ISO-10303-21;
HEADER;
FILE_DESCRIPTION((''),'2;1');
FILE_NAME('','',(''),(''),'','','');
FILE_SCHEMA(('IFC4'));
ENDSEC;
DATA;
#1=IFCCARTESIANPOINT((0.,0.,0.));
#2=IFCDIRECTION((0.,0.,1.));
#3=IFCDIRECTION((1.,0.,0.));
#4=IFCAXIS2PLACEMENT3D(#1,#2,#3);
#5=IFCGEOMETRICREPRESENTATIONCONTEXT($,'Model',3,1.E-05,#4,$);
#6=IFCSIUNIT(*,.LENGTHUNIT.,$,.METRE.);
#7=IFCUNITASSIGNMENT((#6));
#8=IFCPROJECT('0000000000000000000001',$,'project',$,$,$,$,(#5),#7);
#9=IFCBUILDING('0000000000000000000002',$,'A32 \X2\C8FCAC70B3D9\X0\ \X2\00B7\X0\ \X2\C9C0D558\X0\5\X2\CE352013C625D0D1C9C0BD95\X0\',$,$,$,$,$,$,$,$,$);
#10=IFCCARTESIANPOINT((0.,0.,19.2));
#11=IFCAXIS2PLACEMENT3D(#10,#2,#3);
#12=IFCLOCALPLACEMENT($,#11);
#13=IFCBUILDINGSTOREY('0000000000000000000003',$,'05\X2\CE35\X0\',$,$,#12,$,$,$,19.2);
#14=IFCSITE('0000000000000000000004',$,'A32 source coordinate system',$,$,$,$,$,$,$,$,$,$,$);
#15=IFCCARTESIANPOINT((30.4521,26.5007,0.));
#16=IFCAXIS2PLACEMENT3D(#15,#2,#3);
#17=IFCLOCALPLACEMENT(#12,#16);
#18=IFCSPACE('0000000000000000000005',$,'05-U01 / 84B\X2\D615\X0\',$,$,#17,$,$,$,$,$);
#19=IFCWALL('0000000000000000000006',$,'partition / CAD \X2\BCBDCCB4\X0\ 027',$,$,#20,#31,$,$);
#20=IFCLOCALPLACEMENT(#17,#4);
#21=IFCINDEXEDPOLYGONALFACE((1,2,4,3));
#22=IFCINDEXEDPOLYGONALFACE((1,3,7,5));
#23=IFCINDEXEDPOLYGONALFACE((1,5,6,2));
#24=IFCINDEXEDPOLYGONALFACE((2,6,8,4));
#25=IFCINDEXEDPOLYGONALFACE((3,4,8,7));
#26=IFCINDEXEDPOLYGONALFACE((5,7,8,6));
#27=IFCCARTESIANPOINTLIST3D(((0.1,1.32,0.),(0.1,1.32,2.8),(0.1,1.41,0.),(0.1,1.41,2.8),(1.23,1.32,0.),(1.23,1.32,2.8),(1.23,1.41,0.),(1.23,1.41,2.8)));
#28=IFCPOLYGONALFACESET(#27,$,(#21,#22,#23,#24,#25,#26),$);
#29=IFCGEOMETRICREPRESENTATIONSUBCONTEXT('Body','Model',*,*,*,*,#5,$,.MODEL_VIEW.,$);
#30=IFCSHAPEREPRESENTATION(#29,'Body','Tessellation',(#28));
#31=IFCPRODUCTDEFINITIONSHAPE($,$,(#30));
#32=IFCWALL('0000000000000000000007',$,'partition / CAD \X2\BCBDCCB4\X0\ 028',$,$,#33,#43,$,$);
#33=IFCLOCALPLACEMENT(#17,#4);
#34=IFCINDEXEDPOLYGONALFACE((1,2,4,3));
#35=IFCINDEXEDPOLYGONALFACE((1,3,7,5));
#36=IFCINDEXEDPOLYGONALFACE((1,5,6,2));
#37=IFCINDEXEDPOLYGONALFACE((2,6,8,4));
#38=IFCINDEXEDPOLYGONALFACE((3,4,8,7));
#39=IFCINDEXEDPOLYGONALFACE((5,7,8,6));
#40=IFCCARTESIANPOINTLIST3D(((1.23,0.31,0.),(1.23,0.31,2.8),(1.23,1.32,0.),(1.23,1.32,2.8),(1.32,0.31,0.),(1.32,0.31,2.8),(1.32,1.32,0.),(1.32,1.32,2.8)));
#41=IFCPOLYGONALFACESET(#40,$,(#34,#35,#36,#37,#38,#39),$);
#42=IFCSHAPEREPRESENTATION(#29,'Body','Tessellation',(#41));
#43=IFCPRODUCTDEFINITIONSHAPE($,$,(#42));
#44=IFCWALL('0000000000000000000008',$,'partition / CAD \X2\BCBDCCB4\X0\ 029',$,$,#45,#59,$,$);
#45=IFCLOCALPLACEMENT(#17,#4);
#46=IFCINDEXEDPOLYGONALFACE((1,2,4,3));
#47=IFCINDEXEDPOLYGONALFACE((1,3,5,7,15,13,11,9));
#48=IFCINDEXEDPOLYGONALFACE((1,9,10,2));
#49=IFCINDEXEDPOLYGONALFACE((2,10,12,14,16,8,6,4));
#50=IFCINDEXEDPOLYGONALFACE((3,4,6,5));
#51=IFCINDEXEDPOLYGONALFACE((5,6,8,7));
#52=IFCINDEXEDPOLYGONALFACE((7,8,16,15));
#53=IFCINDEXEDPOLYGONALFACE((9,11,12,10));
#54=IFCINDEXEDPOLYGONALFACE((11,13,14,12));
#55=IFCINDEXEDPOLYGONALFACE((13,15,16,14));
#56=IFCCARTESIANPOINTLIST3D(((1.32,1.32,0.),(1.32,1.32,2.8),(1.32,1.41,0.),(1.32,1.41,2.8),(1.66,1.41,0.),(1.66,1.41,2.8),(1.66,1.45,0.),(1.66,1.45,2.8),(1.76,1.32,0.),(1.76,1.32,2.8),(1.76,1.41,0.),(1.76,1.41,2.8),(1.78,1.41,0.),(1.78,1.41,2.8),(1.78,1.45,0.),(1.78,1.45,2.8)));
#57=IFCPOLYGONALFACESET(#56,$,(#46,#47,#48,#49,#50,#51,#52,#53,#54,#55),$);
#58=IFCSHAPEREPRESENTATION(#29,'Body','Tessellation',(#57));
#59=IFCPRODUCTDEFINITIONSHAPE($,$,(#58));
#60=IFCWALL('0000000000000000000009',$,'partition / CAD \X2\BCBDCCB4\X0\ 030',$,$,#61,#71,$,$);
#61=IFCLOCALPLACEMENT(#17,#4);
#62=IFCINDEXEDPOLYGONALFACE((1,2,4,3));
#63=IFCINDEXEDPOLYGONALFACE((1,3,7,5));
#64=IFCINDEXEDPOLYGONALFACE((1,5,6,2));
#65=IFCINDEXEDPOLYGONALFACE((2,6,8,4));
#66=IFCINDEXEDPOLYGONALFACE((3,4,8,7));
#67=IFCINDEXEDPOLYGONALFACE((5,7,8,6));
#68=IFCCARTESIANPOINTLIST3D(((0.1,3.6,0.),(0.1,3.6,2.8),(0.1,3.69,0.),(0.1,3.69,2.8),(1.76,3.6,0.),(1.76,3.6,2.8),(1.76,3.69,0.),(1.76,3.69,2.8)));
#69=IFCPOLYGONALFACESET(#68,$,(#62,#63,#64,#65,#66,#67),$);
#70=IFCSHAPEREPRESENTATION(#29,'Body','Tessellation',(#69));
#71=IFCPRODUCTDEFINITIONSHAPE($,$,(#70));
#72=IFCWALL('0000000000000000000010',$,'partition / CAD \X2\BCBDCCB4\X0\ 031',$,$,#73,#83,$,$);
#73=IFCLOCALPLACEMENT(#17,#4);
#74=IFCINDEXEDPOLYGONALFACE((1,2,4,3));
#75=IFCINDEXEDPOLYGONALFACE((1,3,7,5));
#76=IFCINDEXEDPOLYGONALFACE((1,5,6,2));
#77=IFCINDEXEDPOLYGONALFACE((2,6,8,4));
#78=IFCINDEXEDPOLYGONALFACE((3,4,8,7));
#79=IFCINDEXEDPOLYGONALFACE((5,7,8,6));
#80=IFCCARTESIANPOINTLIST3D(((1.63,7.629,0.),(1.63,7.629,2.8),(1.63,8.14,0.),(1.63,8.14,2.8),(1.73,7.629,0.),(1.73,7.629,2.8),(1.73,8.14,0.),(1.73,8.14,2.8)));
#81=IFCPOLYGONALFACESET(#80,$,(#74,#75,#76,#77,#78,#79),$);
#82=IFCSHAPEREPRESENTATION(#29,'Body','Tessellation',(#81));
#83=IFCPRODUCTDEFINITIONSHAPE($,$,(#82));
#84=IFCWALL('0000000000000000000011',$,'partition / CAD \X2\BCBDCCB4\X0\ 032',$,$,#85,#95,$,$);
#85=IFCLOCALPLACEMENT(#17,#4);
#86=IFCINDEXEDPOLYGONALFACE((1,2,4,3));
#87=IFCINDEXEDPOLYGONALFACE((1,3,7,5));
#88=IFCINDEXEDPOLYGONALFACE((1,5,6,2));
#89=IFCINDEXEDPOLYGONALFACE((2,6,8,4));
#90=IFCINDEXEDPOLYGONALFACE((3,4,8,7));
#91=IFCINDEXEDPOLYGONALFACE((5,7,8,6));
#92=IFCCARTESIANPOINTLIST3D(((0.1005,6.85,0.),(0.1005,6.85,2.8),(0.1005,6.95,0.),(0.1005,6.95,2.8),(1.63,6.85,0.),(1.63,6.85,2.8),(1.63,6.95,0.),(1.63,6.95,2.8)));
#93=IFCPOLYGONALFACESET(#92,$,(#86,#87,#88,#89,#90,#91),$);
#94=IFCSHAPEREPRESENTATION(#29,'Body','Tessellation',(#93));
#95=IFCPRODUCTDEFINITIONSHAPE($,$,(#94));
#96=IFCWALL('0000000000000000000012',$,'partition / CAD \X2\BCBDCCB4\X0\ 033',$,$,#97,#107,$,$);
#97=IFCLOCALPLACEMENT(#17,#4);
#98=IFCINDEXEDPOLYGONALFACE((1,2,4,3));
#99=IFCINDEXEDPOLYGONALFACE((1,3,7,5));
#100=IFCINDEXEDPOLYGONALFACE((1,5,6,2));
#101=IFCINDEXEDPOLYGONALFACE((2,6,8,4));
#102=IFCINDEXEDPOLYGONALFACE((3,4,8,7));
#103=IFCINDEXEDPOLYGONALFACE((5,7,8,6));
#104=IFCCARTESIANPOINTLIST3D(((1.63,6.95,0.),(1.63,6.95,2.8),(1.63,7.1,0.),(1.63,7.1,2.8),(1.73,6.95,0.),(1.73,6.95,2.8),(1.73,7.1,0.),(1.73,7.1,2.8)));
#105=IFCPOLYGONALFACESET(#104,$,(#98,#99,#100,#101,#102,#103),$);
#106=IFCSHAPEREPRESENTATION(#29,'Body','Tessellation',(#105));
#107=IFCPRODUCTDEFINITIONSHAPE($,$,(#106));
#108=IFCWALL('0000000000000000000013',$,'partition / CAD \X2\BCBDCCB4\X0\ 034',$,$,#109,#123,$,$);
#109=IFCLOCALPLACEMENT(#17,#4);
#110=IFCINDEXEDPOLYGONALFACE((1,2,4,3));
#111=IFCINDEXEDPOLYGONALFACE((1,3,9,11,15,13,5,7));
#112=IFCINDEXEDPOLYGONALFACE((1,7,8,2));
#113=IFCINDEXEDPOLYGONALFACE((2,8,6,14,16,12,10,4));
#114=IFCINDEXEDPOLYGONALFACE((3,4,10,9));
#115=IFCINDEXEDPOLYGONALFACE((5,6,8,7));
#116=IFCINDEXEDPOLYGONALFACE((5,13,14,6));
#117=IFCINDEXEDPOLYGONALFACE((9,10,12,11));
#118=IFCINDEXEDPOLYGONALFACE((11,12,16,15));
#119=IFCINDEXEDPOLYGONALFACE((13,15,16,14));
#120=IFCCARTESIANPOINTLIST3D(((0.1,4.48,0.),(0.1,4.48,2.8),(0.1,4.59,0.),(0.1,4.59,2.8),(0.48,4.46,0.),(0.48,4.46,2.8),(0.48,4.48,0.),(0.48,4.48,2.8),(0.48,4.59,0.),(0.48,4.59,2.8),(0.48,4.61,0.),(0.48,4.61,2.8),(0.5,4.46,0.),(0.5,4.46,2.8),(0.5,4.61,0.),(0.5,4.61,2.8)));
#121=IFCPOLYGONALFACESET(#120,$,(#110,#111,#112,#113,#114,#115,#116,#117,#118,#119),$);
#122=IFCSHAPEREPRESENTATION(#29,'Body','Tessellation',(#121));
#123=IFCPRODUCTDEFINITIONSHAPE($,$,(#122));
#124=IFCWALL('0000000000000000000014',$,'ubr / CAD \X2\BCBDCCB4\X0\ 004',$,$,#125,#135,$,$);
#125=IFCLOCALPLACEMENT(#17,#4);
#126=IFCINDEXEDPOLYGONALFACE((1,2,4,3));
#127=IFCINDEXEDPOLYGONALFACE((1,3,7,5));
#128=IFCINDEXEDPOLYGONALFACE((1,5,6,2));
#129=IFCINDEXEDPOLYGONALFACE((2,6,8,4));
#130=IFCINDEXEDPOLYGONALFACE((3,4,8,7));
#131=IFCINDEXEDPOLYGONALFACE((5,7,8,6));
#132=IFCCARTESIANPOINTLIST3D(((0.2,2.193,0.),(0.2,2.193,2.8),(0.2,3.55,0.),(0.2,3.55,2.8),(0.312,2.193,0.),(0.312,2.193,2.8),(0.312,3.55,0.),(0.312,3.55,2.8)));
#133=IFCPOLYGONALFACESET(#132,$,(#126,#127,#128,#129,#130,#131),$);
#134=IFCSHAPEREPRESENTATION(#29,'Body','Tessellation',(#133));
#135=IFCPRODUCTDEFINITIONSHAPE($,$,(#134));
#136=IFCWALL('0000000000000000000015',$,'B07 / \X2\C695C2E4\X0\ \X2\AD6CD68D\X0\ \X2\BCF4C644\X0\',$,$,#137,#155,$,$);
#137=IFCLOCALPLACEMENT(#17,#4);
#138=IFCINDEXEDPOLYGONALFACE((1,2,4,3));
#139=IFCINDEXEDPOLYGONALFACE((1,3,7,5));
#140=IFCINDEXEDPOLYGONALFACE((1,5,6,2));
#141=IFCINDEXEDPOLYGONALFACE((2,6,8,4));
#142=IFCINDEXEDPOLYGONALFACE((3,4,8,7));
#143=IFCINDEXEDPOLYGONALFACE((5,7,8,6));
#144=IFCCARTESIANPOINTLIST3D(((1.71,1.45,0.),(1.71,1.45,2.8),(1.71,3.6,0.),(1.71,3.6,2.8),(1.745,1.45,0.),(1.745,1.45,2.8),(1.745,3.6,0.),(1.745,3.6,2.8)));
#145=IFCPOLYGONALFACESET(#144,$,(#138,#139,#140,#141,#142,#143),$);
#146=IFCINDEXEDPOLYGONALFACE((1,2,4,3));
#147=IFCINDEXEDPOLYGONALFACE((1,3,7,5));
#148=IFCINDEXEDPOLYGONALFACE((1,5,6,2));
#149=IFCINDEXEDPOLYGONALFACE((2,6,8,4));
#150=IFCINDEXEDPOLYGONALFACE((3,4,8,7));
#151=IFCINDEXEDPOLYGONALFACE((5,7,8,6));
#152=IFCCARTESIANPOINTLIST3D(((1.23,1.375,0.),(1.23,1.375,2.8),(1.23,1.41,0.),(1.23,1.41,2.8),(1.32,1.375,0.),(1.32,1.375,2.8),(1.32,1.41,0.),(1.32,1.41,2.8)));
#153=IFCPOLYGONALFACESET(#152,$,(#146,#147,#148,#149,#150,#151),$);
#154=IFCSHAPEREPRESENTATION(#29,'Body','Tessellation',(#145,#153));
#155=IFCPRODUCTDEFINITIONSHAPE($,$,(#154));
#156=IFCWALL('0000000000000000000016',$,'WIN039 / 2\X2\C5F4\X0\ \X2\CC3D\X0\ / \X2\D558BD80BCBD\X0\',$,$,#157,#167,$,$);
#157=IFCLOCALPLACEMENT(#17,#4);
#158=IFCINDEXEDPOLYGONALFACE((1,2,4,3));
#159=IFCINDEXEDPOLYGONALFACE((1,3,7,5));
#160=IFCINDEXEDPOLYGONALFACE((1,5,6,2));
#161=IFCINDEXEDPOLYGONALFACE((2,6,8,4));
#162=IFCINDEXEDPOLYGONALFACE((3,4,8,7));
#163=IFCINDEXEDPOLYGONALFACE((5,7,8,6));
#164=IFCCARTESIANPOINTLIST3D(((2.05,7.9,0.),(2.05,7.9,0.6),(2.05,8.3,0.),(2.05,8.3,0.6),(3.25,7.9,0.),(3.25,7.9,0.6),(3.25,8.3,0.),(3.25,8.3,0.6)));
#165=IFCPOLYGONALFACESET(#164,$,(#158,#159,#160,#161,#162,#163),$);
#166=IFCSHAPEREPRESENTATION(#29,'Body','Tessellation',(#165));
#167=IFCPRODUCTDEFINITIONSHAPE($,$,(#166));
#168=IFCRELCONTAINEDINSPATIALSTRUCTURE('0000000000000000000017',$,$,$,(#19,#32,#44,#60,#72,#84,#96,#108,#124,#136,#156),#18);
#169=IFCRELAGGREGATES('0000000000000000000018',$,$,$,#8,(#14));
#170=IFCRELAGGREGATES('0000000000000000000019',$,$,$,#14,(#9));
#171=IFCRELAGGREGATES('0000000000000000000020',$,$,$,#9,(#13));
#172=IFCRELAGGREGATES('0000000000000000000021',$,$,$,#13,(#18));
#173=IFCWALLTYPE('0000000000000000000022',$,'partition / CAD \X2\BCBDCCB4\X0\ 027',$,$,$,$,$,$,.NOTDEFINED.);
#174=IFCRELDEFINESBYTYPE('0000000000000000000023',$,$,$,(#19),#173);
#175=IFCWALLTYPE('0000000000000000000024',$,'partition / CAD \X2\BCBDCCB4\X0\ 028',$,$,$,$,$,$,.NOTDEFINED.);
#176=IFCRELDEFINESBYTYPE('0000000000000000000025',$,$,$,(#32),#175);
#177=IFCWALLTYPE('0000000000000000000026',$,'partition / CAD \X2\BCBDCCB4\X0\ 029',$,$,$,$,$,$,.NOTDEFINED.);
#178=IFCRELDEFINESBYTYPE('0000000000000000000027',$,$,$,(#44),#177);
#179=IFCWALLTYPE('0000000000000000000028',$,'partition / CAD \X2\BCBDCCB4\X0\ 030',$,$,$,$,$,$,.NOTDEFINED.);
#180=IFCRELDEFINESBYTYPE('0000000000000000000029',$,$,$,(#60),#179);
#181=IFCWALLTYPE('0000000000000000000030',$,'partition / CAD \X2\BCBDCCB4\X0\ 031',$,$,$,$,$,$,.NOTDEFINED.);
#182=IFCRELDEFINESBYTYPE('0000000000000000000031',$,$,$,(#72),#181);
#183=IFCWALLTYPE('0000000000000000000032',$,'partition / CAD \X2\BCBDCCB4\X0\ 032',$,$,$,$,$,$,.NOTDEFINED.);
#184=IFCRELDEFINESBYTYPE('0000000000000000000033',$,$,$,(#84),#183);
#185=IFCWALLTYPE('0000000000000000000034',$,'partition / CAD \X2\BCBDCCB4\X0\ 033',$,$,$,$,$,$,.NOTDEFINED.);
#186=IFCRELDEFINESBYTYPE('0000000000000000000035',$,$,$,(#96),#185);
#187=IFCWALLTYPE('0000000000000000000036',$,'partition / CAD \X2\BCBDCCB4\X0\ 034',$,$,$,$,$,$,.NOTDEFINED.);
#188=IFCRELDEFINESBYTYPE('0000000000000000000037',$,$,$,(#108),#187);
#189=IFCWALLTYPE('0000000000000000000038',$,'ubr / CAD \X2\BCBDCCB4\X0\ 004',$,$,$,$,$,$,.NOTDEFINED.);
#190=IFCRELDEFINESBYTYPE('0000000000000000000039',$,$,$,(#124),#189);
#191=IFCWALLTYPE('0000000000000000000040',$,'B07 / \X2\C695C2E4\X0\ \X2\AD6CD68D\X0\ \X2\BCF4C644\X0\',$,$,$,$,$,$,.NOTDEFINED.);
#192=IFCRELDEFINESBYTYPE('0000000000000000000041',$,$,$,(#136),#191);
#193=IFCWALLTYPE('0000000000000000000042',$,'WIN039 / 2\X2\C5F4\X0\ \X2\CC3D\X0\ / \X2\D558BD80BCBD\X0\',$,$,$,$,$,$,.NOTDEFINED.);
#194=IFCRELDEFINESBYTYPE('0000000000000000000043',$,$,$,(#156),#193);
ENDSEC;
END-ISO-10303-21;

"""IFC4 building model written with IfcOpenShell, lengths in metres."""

from ifc_helpers import new_model, si_unit, frame, origin, origin_with_axes, place, context, subcontext, project, spatial, polyline, outline, extrude, source, transform, mapped, type_object, type_shapes, element, save


model = new_model("IFC4")

# Units and contexts
model_context = context("Model", 3, precision=1e-05, world=origin_with_axes())
body_context = subcontext(model_context, "Body", "Model", "MODEL_VIEW")
ifc_project = project(units=[si_unit("LENGTHUNIT", "METRE")], contexts=[model_context])

# Site, building, storey, space
site = spatial("IfcSite", under=ifc_project, Name="A32 source coordinate system")
building = spatial("IfcBuilding", under=site, Name="A32 주거동 · 지하5층–옥탑지붕")
storey_placement = place(None, frame((0.0, 0.0, 19.2), z_axis=(0.0, 0.0, 1.0), x_axis=(1.0, 0.0, 0.0)))
storey = spatial("IfcBuildingStorey", under=building, at=storey_placement, Name="05층", Elevation=19.2)
space_placement = place(storey_placement, frame((30.4521, 26.5007, 0.0), z_axis=(0.0, 0.0, 1.0), x_axis=(1.0, 0.0, 0.0)))
space = spatial("IfcSpace", under=storey, at=space_placement, Name="05-U01 / 84B형")

# Walls
wall_type_1 = type_object("IfcWallType", Name="partition / CAD 벽체 027", PredefinedType="NOTDEFINED")
shared_shape_1 = source(origin(), body_context, "Body", "SweptSolid", [
    extrude(outline(polyline([(0.1, 1.32), (0.1, 1.41), (1.23, 1.41), (1.23, 1.32), (0.1, 1.32)])), origin(), (0.0, 0.0, 1.0), 2.8),
])
type_shapes(wall_type_1, [shared_shape_1])
wall_1_placement = place(space_placement, origin_with_axes())
element("IfcWall", 1, at=wall_1_placement, inside=space, type_object=wall_type_1, Name="partition / CAD 벽체 027", context=body_context, shape_type="MappedRepresentation", body=[
    mapped(shared_shape_1, transform((0.0, 0.0, 0.0), scale=1.0)),
])
wall_type_2 = type_object("IfcWallType", Name="partition / CAD 벽체 028", PredefinedType="NOTDEFINED")
shared_shape_2 = source(origin(), body_context, "Body", "SweptSolid", [
    extrude(outline(polyline([(1.32, 0.31), (1.23, 0.31), (1.23, 1.32), (1.32, 1.32), (1.32, 0.31)])), origin(), (0.0, 0.0, 1.0), 2.8),
])
type_shapes(wall_type_2, [shared_shape_2])
wall_2_placement = place(space_placement, origin_with_axes())
element("IfcWall", 2, at=wall_2_placement, inside=space, type_object=wall_type_2, Name="partition / CAD 벽체 028", context=body_context, shape_type="MappedRepresentation", body=[
    mapped(shared_shape_2, transform((0.0, 0.0, 0.0), scale=1.0)),
])
wall_type_3 = type_object("IfcWallType", Name="partition / CAD 벽체 029", PredefinedType="NOTDEFINED")
shared_shape_3 = source(origin(), body_context, "Body", "SweptSolid", [
    extrude(outline(polyline([(1.66, 1.41), (1.66, 1.45), (1.78, 1.45), (1.78, 1.41), (1.76, 1.41), (1.76, 1.32), (1.32, 1.32), (1.32, 1.41), (1.66, 1.41)])), origin(), (0.0, 0.0, 1.0), 2.8),
])
type_shapes(wall_type_3, [shared_shape_3])
wall_3_placement = place(space_placement, origin_with_axes())
element("IfcWall", 3, at=wall_3_placement, inside=space, type_object=wall_type_3, Name="partition / CAD 벽체 029", context=body_context, shape_type="MappedRepresentation", body=[
    mapped(shared_shape_3, transform((0.0, 0.0, 0.0), scale=1.0)),
])
wall_type_4 = type_object("IfcWallType", Name="partition / CAD 벽체 030", PredefinedType="NOTDEFINED")
shared_shape_4 = source(origin(), body_context, "Body", "SweptSolid", [
    extrude(outline(polyline([(1.76, 3.69), (1.76, 3.6), (0.1, 3.6), (0.1, 3.69), (1.76, 3.69)])), origin(), (0.0, 0.0, 1.0), 2.8),
])
type_shapes(wall_type_4, [shared_shape_4])
wall_4_placement = place(space_placement, origin_with_axes())
element("IfcWall", 4, at=wall_4_placement, inside=space, type_object=wall_type_4, Name="partition / CAD 벽체 030", context=body_context, shape_type="MappedRepresentation", body=[
    mapped(shared_shape_4, transform((0.0, 0.0, 0.0), scale=1.0)),
])
wall_type_5 = type_object("IfcWallType", Name="partition / CAD 벽체 031", PredefinedType="NOTDEFINED")
shared_shape_5 = source(origin(), body_context, "Body", "SweptSolid", [
    extrude(outline(polyline([(1.63, 8.14), (1.73, 8.14), (1.73, 7.629), (1.63, 7.629), (1.63, 8.14)])), origin(), (0.0, 0.0, 1.0), 2.8),
])
type_shapes(wall_type_5, [shared_shape_5])
wall_5_placement = place(space_placement, origin_with_axes())
element("IfcWall", 5, at=wall_5_placement, inside=space, type_object=wall_type_5, Name="partition / CAD 벽체 031", context=body_context, shape_type="MappedRepresentation", body=[
    mapped(shared_shape_5, transform((0.0, 0.0, 0.0), scale=1.0)),
])
wall_type_6 = type_object("IfcWallType", Name="partition / CAD 벽체 032", PredefinedType="NOTDEFINED")
shared_shape_6 = source(origin(), body_context, "Body", "SweptSolid", [
    extrude(outline(polyline([(0.1005, 6.95), (1.63, 6.95), (1.63, 6.85), (0.1005, 6.85), (0.1005, 6.95)])), origin(), (0.0, 0.0, 1.0), 2.8),
])
type_shapes(wall_type_6, [shared_shape_6])
wall_6_placement = place(space_placement, origin_with_axes())
element("IfcWall", 6, at=wall_6_placement, inside=space, type_object=wall_type_6, Name="partition / CAD 벽체 032", context=body_context, shape_type="MappedRepresentation", body=[
    mapped(shared_shape_6, transform((0.0, 0.0, 0.0), scale=1.0)),
])
wall_type_7 = type_object("IfcWallType", Name="partition / CAD 벽체 033", PredefinedType="NOTDEFINED")
shared_shape_7 = source(origin(), body_context, "Body", "SweptSolid", [
    extrude(outline(polyline([(1.63, 7.1), (1.73, 7.1), (1.73, 6.95), (1.63, 6.95), (1.63, 7.1)])), origin(), (0.0, 0.0, 1.0), 2.8),
])
type_shapes(wall_type_7, [shared_shape_7])
wall_7_placement = place(space_placement, origin_with_axes())
element("IfcWall", 7, at=wall_7_placement, inside=space, type_object=wall_type_7, Name="partition / CAD 벽체 033", context=body_context, shape_type="MappedRepresentation", body=[
    mapped(shared_shape_7, transform((0.0, 0.0, 0.0), scale=1.0)),
])
wall_type_8 = type_object("IfcWallType", Name="partition / CAD 벽체 034", PredefinedType="NOTDEFINED")
shared_shape_8 = source(origin(), body_context, "Body", "SweptSolid", [
    extrude(outline(polyline([(0.48, 4.61), (0.5, 4.61), (0.5, 4.46), (0.48, 4.46), (0.48, 4.48), (0.1, 4.48), (0.1, 4.59), (0.48, 4.59), (0.48, 4.61)])), origin(), (0.0, 0.0, 1.0), 2.8),
])
type_shapes(wall_type_8, [shared_shape_8])
wall_8_placement = place(space_placement, origin_with_axes())
element("IfcWall", 8, at=wall_8_placement, inside=space, type_object=wall_type_8, Name="partition / CAD 벽체 034", context=body_context, shape_type="MappedRepresentation", body=[
    mapped(shared_shape_8, transform((0.0, 0.0, 0.0), scale=1.0)),
])
wall_type_9 = type_object("IfcWallType", Name="ubr / CAD 벽체 004", PredefinedType="NOTDEFINED")
shared_shape_9 = source(origin(), body_context, "Body", "SweptSolid", [
    extrude(outline(polyline([(0.312, 2.193), (0.2, 2.193), (0.2, 3.55), (0.312, 3.55), (0.312, 2.193)])), origin(), (0.0, 0.0, 1.0), 2.8),
])
type_shapes(wall_type_9, [shared_shape_9])
wall_9_placement = place(space_placement, origin_with_axes())
element("IfcWall", 9, at=wall_9_placement, inside=space, type_object=wall_type_9, Name="ubr / CAD 벽체 004", context=body_context, shape_type="MappedRepresentation", body=[
    mapped(shared_shape_9, transform((0.0, 0.0, 0.0), scale=1.0)),
])
wall_type_10 = type_object("IfcWallType", Name="B07 / 욕실 구획 보완", PredefinedType="NOTDEFINED")
shared_shape_10 = source(origin(), body_context, "Body", "SweptSolid", [
    extrude(outline(polyline([(1.71, 1.45), (1.71, 3.6), (1.745, 3.6), (1.745, 1.45), (1.71, 1.45)])), origin(), (0.0, 0.0, 1.0), 2.8),
    extrude(outline(polyline([(1.32, 1.41), (1.32, 1.375), (1.23, 1.375), (1.23, 1.41), (1.32, 1.41)])), origin(), (0.0, 0.0, 1.0), 2.8),
])
type_shapes(wall_type_10, [shared_shape_10])
wall_10_placement = place(space_placement, origin_with_axes())
element("IfcWall", 10, at=wall_10_placement, inside=space, type_object=wall_type_10, Name="B07 / 욕실 구획 보완", context=body_context, shape_type="MappedRepresentation", body=[
    mapped(shared_shape_10, transform((0.0, 0.0, 0.0), scale=1.0)),
])
wall_type_11 = type_object("IfcWallType", Name="WIN039 / 2열 창 / 하부벽", PredefinedType="NOTDEFINED")
shared_shape_11 = source(origin(), body_context, "Body", "SweptSolid", [
    extrude(outline(polyline([(2.05, 8.3), (3.25, 8.3), (3.25, 7.9), (2.05, 7.9), (2.05, 8.3)])), origin(), (0.0, 0.0, 1.0), 0.6),
])
type_shapes(wall_type_11, [shared_shape_11])
wall_11_placement = place(space_placement, origin_with_axes())
element("IfcWall", 11, at=wall_11_placement, inside=space, type_object=wall_type_11, Name="WIN039 / 2열 창 / 하부벽", context=body_context, shape_type="MappedRepresentation", body=[
    mapped(shared_shape_11, transform((0.0, 0.0, 0.0), scale=1.0)),
])

save(model, "model.ifc")
